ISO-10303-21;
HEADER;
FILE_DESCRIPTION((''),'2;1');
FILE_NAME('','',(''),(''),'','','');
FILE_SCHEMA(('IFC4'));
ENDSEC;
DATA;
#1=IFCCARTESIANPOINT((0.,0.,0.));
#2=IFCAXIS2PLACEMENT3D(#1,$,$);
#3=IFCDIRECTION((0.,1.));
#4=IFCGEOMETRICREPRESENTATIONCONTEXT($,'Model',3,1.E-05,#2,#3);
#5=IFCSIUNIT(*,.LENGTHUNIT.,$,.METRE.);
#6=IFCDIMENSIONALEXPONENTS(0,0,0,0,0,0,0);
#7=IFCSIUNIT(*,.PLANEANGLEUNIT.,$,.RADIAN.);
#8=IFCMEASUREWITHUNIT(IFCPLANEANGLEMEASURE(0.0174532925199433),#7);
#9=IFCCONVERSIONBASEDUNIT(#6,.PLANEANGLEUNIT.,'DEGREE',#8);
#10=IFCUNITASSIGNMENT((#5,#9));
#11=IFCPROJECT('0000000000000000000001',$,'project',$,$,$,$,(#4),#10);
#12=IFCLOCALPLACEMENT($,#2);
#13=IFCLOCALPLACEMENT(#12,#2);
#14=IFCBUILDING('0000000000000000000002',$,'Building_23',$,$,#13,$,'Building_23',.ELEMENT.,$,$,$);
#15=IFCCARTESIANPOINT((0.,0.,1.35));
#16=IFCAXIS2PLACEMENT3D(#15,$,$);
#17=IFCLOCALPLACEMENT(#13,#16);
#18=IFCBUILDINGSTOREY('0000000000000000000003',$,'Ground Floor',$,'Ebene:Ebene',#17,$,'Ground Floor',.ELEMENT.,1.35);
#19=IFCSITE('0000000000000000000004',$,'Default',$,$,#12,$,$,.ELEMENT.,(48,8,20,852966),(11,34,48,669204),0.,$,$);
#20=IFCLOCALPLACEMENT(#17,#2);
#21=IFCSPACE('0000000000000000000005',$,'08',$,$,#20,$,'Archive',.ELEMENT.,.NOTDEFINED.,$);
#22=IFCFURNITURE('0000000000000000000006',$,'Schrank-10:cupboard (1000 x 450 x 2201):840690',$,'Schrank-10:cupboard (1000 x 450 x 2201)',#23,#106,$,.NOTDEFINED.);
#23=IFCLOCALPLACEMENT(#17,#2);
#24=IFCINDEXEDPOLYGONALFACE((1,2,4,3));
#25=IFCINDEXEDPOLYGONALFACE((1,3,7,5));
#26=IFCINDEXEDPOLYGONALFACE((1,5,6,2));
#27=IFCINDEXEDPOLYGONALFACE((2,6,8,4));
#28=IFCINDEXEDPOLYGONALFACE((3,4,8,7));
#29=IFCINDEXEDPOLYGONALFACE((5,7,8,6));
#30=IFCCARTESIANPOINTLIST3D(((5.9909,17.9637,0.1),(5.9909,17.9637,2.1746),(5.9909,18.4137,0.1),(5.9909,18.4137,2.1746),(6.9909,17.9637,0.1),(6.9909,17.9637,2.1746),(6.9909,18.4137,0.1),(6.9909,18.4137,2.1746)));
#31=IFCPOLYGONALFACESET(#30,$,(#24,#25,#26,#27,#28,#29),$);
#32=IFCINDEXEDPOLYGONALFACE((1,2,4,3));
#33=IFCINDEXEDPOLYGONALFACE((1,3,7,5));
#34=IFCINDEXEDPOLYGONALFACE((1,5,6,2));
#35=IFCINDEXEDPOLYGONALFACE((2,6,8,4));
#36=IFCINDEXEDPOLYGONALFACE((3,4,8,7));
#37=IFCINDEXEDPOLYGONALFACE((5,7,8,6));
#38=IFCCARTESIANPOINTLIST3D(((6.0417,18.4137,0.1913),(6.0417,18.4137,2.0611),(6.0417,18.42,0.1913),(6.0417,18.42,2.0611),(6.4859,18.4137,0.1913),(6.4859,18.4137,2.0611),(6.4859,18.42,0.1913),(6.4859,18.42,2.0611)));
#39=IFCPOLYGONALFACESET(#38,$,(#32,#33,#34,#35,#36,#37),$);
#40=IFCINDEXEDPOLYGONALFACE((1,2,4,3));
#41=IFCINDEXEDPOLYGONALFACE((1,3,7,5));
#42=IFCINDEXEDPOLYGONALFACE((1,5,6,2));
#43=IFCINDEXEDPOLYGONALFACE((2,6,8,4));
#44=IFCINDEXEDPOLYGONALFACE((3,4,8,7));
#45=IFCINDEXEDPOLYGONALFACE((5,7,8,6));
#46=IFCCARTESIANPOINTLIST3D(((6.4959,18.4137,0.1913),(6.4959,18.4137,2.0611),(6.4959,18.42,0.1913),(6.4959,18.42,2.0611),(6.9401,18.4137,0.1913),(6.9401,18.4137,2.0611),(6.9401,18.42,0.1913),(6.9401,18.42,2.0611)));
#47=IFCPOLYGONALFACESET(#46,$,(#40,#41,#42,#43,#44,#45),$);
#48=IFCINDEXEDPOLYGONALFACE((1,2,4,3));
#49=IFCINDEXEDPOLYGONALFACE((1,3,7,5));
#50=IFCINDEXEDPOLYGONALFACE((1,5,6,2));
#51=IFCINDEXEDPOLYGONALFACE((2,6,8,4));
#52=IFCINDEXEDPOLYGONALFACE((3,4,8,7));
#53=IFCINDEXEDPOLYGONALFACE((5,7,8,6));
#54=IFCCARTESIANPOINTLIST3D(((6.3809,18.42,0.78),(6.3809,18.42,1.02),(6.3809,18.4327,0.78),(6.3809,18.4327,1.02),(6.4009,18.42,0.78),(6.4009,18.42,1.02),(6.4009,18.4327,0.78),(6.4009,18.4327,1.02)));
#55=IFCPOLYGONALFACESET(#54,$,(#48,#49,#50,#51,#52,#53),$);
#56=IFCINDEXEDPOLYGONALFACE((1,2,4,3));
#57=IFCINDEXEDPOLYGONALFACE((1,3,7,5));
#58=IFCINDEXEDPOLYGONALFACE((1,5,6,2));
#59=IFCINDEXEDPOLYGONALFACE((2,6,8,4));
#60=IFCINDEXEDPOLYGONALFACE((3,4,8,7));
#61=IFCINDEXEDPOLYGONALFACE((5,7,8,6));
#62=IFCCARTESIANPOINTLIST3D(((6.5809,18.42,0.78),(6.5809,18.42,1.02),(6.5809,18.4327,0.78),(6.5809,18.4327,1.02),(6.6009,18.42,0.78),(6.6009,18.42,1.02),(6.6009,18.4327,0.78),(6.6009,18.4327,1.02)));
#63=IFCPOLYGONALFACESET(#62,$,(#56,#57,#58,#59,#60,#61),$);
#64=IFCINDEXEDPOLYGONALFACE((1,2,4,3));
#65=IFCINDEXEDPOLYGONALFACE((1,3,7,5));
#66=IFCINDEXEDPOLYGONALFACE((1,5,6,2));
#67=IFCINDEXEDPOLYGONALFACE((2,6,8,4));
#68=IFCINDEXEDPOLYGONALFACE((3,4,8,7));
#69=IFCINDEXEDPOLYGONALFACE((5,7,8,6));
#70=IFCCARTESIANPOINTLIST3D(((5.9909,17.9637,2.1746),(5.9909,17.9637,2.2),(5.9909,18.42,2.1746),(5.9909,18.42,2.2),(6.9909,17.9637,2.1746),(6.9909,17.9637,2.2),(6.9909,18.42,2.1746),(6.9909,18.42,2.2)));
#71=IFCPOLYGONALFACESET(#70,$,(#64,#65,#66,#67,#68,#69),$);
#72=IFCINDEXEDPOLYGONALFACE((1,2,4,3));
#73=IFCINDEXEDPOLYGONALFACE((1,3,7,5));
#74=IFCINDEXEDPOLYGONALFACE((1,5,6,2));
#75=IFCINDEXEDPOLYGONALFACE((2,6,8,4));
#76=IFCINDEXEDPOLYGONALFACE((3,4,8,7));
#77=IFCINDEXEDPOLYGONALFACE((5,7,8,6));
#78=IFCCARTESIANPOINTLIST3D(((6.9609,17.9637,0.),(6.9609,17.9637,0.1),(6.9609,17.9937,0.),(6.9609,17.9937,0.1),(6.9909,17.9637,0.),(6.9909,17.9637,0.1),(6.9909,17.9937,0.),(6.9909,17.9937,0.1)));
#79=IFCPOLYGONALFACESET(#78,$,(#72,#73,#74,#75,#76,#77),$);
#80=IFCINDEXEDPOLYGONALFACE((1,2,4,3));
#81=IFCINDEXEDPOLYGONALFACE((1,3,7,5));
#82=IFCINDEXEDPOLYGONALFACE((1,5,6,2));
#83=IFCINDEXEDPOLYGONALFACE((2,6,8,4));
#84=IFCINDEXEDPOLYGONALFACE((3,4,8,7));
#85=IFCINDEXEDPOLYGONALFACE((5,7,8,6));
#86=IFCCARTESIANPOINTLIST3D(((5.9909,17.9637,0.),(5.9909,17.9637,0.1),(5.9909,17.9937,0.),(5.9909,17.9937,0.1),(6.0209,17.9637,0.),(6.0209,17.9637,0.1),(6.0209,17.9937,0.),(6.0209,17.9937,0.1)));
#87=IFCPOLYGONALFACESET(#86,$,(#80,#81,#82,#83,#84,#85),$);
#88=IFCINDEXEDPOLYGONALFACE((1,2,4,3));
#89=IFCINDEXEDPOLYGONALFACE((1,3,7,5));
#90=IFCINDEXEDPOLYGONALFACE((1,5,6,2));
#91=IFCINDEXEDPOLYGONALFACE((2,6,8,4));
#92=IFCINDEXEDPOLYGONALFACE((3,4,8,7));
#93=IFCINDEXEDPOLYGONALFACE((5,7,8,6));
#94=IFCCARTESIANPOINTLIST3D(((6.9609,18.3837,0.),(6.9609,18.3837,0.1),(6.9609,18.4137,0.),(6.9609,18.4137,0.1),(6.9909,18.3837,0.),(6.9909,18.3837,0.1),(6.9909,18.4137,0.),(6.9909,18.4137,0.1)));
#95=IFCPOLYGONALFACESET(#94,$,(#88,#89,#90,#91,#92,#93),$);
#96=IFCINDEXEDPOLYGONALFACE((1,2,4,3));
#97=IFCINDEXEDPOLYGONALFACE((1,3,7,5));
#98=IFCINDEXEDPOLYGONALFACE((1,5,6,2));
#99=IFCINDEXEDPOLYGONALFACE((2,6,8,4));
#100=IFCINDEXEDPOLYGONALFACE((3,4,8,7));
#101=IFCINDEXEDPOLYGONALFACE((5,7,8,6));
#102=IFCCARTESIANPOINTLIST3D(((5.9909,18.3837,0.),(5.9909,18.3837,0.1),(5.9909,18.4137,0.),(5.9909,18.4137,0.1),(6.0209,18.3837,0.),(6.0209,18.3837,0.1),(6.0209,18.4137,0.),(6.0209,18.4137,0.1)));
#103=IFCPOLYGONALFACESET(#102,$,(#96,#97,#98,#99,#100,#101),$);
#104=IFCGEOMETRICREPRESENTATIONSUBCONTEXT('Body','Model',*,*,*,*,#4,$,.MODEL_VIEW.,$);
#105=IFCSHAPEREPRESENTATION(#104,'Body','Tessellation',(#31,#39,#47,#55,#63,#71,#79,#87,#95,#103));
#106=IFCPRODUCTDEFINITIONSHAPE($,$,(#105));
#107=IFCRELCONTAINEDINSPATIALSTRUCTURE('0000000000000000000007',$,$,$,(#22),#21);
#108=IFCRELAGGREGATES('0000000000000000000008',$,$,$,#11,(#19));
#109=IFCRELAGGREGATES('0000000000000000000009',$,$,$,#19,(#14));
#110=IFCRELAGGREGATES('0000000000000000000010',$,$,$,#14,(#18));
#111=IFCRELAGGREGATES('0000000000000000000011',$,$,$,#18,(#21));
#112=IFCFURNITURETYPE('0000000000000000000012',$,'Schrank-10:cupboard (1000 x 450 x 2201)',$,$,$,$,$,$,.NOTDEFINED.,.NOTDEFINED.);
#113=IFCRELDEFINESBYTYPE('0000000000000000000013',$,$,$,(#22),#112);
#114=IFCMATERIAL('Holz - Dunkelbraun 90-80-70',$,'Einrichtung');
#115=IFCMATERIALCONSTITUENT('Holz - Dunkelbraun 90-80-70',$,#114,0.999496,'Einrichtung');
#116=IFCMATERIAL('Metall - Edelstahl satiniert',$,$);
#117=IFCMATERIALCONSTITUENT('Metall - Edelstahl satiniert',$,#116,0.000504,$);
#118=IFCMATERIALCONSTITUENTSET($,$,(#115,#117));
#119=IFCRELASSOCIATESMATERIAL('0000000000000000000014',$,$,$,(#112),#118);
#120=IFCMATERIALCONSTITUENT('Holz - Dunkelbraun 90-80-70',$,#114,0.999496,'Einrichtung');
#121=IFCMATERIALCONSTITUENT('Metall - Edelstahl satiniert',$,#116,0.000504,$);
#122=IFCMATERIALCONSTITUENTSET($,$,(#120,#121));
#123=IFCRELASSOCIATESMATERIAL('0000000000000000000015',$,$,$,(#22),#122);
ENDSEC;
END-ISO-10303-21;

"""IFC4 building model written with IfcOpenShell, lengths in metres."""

from ifc_helpers import new_model, entity, si_unit, converted_unit, direction, frame, origin, place, context, subcontext, project, spatial, indexed_curve, outline, extrude, source, transform, mapped, material, constituent, constituent_set, type_object, type_shapes, element, save


model = new_model("IFC4")

# Units and contexts
model_context = context("Model", 3, precision=1e-05, world=origin(), true_north=direction((0.0, 1.0)))
body_context = subcontext(model_context, "Body", "Model", "MODEL_VIEW")
ifc_project = project(units=[si_unit("LENGTHUNIT", "METRE"), converted_unit("PLANEANGLEUNIT", "DEGREE", entity("IfcPlaneAngleMeasure", 0.0174532925199433), si_unit("PLANEANGLEUNIT", "RADIAN"), dimensions=[0, 0, 0, 0, 0, 0, 0])], contexts=[model_context])

# Site, building, storey
site_placement = place(None, origin())
site = spatial("IfcSite", under=ifc_project, at=site_placement, Name="Default", CompositionType="ELEMENT", RefLatitude=(48, 8, 20, 852966), RefLongitude=(11, 34, 48, 669204), RefElevation=0.0)
building_placement = place(site_placement, origin())
building = spatial("IfcBuilding", under=site, at=building_placement, Name="Building_23", LongName="Building_23", CompositionType="ELEMENT")
storey_placement = place(building_placement, frame((0.0, 0.0, 1.35)))
storey = spatial("IfcBuildingStorey", under=building, at=storey_placement, Name="Ground Floor", ObjectType="Ebene:Ebene", LongName="Ground Floor", CompositionType="ELEMENT", Elevation=1.35)

# Shared definitions
space_placement = place(storey_placement, origin())
space = spatial("IfcSpace", under=storey, at=space_placement, Name="08", LongName="Archive", CompositionType="ELEMENT", PredefinedType="NOTDEFINED")

# Furniture
ifc_material_1 = material(Name="Holz - Dunkelbraun 90-80-70", Category="Einrichtung")
ifc_material_2 = material(Name="Metall - Edelstahl satiniert")
ifc_constituent_1 = constituent(ifc_material_1, Name="Holz - Dunkelbraun 90-80-70", Category="Einrichtung", fraction=0.999496)
ifc_constituent_2 = constituent(ifc_material_2, Name="Metall - Edelstahl satiniert", fraction=0.000504)
ifc_constituent_set_1 = constituent_set(constituents=[ifc_constituent_1, ifc_constituent_2])
furniture_type = type_object("IfcFurnitureType", Name="Schrank-10:cupboard (1000 x 450 x 2201)", AssemblyPlace="NOTDEFINED", PredefinedType="NOTDEFINED", material=ifc_constituent_set_1)
shared_shape_1 = source(origin(), body_context, "Body", "SweptSolid", [
    extrude(outline(indexed_curve([(-0.225, -0.5), (0.225, -0.5), (0.225, 0.5), (-0.225, 0.5), (-0.225, -0.5)], self_intersect=False)), frame((-0.2692, -0.3632, 0.1), z_axis=(0.0, 0.0, 1.0), x_axis=(0.0, 1.0, 0.0)), (0.0, 0.0, 1.0), 2.0746),
    extrude(outline(indexed_curve([(-0.0032, -0.2221), (0.0032, -0.2221), (0.0032, 0.2221), (-0.0032, 0.2221), (-0.0032, -0.2221)], self_intersect=False)), frame((-0.0421, -0.5913, 0.1913), z_axis=(0.0, 0.0, 1.0), x_axis=(0.0, 1.0, 0.0)), (0.0, 0.0, 1.0), 1.8698),
    extrude(outline(indexed_curve([(-0.0032, -0.2221), (0.0032, -0.2221), (0.0032, 0.2221), (-0.0032, 0.2221), (-0.0032, -0.2221)], self_intersect=False)), frame((-0.4963, -0.5913, 0.1913), z_axis=(0.0, 0.0, 1.0), x_axis=(0.0, 1.0, 0.0)), (0.0, 0.0, 1.0), 1.8698),
    extrude(outline(indexed_curve([(-0.0063, -0.01), (0.0063, -0.01), (0.0063, 0.01), (-0.0063, 0.01), (-0.0063, -0.01)], self_intersect=False)), frame((-0.1692, -0.6009, 0.78), z_axis=(0.0, 0.0, 1.0), x_axis=(0.0, 1.0, 0.0)), (0.0, 0.0, 1.0), 0.24),
    extrude(outline(indexed_curve([(-0.0063, -0.01), (0.0063, -0.01), (0.0063, 0.01), (-0.0063, 0.01), (-0.0063, -0.01)], self_intersect=False)), frame((-0.3692, -0.6009, 0.78), z_axis=(0.0, 0.0, 1.0), x_axis=(0.0, 1.0, 0.0)), (0.0, 0.0, 1.0), 0.24),
    extrude(outline(indexed_curve([(-0.5, -0.2282), (0.5, -0.2282), (0.5, 0.2282), (-0.5, 0.2282), (-0.5, -0.2282)], self_intersect=False)), frame((-0.2692, -0.3663, 2.1746), z_axis=(0.0, 0.0, 1.0), x_axis=(-1.0, 0.0, 0.0)), (0.0, 0.0, 1.0), 0.0254),
    extrude(outline(indexed_curve([(-0.015, -0.015), (0.015, -0.015), (0.015, 0.015), (-0.015, 0.015), (-0.015, -0.015)], self_intersect=False)), frame((-0.7542, -0.1532, 0.0), z_axis=(0.0, 0.0, 1.0), x_axis=(-1.0, 0.0, 0.0)), (0.0, 0.0, 1.0), 0.1),
    extrude(outline(indexed_curve([(-0.015, -0.015), (0.015, -0.015), (0.015, 0.015), (-0.015, 0.015), (-0.015, -0.015)], self_intersect=False)), frame((0.2158, -0.1532, 0.0), z_axis=(0.0, 0.0, 1.0), x_axis=(0.0, -1.0, 0.0)), (0.0, 0.0, 1.0), 0.1),
    extrude(outline(indexed_curve([(-0.015, -0.015), (0.015, -0.015), (0.015, 0.015), (-0.015, 0.015), (-0.015, -0.015)], self_intersect=False)), frame((-0.7542, -0.5732, 0.0), z_axis=(0.0, 0.0, 1.0), x_axis=(0.0, 1.0, 0.0)), (0.0, 0.0, 1.0), 0.1),
    extrude(outline(indexed_curve([(-0.015, -0.015), (0.015, -0.015), (0.015, 0.015), (-0.015, 0.015), (-0.015, -0.015)], self_intersect=False)), frame((0.2158, -0.5732, 0.0)), (0.0, 0.0, 1.0), 0.1),
])
type_shapes(furniture_type, [shared_shape_1])
ifc_constituent_3 = constituent(ifc_material_1, Name="Holz - Dunkelbraun 90-80-70", Category="Einrichtung", fraction=0.999496)
ifc_constituent_4 = constituent(ifc_material_2, Name="Metall - Edelstahl satiniert", fraction=0.000504)
ifc_constituent_set_2 = constituent_set(constituents=[ifc_constituent_3, ifc_constituent_4])
furniture_1_placement = place(space_placement, frame((6.2217, 17.8255, 0.0), z_axis=(0.0, 0.0, 1.0), x_axis=(-1.0, 0.0, 0.0)))
element("IfcFurniture", 1, at=furniture_1_placement, inside=space, type_object=furniture_type, material=ifc_constituent_set_2, Name="Schrank-10:cupboard (1000 x 450 x 2201):840690", ObjectType="Schrank-10:cupboard (1000 x 450 x 2201)", PredefinedType="NOTDEFINED", context=body_context, shape_type="MappedRepresentation", body=[
    mapped(shared_shape_1, transform((0.0, 0.0, 0.0), scale=1.0)),
])

save(model, "model.ifc")
